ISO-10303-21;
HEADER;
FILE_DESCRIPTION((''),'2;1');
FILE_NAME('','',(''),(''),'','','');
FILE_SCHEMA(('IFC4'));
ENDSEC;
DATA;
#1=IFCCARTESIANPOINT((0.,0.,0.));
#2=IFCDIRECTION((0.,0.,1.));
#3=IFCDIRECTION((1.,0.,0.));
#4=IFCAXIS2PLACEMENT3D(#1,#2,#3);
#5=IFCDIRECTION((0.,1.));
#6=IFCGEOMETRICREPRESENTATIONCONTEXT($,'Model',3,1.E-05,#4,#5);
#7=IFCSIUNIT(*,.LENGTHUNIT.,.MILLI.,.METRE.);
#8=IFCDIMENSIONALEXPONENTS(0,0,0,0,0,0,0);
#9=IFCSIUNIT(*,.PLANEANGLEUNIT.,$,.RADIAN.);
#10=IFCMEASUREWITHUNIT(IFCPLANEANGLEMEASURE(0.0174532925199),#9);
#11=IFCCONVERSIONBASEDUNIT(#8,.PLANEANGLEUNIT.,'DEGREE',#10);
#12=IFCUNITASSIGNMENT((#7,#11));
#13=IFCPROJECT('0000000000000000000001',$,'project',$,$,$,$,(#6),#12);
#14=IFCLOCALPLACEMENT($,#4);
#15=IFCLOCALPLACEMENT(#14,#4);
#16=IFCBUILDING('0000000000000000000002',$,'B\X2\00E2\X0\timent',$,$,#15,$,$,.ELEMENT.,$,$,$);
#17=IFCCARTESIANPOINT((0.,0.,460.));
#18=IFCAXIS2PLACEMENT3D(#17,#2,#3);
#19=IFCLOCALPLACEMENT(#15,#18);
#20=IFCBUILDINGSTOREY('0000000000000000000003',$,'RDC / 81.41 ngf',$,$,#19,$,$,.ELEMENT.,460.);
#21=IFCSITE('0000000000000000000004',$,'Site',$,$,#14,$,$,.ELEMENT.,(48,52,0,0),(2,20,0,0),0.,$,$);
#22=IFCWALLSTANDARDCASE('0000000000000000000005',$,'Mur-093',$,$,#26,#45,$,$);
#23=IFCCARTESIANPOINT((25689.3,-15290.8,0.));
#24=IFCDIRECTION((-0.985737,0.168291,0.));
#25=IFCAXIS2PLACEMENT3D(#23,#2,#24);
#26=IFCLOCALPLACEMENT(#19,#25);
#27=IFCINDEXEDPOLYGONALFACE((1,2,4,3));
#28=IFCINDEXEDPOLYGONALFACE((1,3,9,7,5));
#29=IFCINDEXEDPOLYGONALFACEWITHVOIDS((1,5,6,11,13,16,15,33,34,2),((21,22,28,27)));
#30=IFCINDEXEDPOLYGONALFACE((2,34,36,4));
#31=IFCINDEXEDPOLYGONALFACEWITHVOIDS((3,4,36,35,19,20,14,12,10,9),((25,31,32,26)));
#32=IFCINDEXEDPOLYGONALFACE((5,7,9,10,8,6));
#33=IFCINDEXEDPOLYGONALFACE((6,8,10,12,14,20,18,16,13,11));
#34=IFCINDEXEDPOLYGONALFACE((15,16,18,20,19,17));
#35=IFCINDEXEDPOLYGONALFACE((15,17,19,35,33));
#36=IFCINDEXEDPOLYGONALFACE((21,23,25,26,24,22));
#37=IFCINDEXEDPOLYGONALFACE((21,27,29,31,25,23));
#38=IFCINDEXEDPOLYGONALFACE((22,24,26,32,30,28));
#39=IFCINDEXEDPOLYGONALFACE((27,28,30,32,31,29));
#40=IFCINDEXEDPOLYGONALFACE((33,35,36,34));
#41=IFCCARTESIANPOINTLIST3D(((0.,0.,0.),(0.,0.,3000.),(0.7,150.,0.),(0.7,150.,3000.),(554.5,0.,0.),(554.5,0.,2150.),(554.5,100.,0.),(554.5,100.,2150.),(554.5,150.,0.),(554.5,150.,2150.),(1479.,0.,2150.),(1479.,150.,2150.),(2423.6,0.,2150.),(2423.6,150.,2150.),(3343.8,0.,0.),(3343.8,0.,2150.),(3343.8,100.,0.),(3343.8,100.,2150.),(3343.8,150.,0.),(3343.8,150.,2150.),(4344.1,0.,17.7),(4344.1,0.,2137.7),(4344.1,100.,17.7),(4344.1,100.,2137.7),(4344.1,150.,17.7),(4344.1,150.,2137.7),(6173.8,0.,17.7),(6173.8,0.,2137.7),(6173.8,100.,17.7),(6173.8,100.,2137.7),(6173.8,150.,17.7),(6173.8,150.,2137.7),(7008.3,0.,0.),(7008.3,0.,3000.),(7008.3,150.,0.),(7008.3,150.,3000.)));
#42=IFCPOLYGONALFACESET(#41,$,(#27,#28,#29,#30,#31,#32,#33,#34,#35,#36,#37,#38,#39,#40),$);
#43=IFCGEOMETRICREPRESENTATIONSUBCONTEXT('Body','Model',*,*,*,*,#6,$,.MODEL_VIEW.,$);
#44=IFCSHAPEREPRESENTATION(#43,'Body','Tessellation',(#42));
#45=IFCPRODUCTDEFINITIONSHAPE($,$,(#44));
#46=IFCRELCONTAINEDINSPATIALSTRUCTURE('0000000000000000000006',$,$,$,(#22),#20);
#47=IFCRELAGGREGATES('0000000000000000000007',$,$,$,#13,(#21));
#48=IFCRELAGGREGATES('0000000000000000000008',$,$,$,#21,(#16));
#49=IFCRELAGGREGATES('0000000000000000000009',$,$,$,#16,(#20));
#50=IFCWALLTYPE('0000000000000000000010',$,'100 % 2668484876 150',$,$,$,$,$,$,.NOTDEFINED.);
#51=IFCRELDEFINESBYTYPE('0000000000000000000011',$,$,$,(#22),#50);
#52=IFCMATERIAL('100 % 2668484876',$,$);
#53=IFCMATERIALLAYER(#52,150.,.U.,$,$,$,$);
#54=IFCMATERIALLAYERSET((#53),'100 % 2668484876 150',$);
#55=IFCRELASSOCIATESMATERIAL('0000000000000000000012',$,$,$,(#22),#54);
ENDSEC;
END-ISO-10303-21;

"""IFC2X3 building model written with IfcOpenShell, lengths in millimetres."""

from ifc_helpers import new_model, entity, si_unit, converted_unit, direction, frame, origin_with_axes, origin_2d_with_axis, place, context, subcontext, project, spatial, polyline, rectangle, outline, extrude, material, layer, layer_set, layer_usage, type_object, element, save


model = new_model("IFC2X3")

# Units and contexts
model_context = context("Model", 3, precision=1e-05, world=origin_with_axes(), true_north=direction((0.0, 1.0)))
body_context = subcontext(model_context, "Body", "Model", "MODEL_VIEW")
ifc_project = project(units=[si_unit("LENGTHUNIT", "METRE", prefix="MILLI"), converted_unit("PLANEANGLEUNIT", "DEGREE", entity("IfcPlaneAngleMeasure", 0.0174532925199), si_unit("PLANEANGLEUNIT", "RADIAN"), dimensions=[0, 0, 0, 0, 0, 0, 0])], contexts=[model_context])

# Site, building, storey
site_placement = place(None, origin_with_axes())
site = spatial("IfcSite", under=ifc_project, at=site_placement, Name="Site", CompositionType="ELEMENT", RefLatitude=(48, 52, 0, 0), RefLongitude=(2, 20, 0, 0), RefElevation=0.0)
building_placement = place(site_placement, origin_with_axes())
building = spatial("IfcBuilding", under=site, at=building_placement, Name="Bâtiment", CompositionType="ELEMENT")
storey_placement = place(building_placement, frame((0.0, 0.0, 460.0), z_axis=(0.0, 0.0, 1.0), x_axis=(1.0, 0.0, 0.0)))
storey = spatial("IfcBuildingStorey", under=building, at=storey_placement, Name="RDC / 81.41 ngf", CompositionType="ELEMENT", Elevation=460.0)

# Shared definitions
ifc_material_1 = material(Name="100 % 2668484876")

# Wall, openings
ifc_layer_1 = layer(ifc_material_1, 150.0, ventilated="UNKNOWN")
ifc_layer_set_1 = layer_set([ifc_layer_1], Name="100 % 2668484876 150")
ifc_layer_usage_1 = layer_usage(ifc_layer_set_1, "AXIS2", "NEGATIVE", 150.0)
wall_type_1 = type_object("IfcWallType", Name="100 % 2668484876 150", PredefinedType="NOTDEFINED")
wall_1_placement = place(storey_placement, frame((25689.3, -15290.8, 0.0), z_axis=(0.0, 0.0, 1.0), x_axis=(-0.985737, 0.168291, 0.0)))
wall_1 = element("IfcWallStandardCase", 1, at=wall_1_placement, inside=storey, type_object=wall_type_1, material=ifc_layer_usage_1, Name="Mur-093", context=body_context, shape_type="SweptSolid", body=[
    extrude(outline(polyline([(0.0, 0.0), (7008.3, 0.0), (7008.3, 150.0), (0.7, 150.0), (0.0, 0.0)])), origin_with_axes(), (0.0, 0.0, 1.0), 3000.0),
])
opening_1_placement = place(wall_1_placement, frame((2883.7, 0.0, 0.0), z_axis=(0.0, 0.0, 1.0), x_axis=(1.0, 0.0, 0.0)))
element("IfcOpeningElement", 2, at=opening_1_placement, cuts=wall_1, context=body_context, shape_type="SweptSolid", body=[
    extrude(rectangle(XDim=920.2, YDim=2150.0, at=origin_2d_with_axis()), frame((0.0, -150.0, 1075.0), z_axis=(0.0, -1.0, 0.0), x_axis=(1.0, 0.0, 0.0)), (0.0, 0.0, -1.0), 250.0),
    extrude(rectangle(XDim=920.2, YDim=2150.0, at=origin_2d_with_axis()), frame((0.0, 300.0, 1075.0), z_axis=(0.0, 1.0, 0.0), x_axis=(1.0, 0.0, 0.0)), (0.0, 0.0, -1.0), 200.0),
])
opening_2_placement = place(wall_1_placement, frame((5258.9, 0.0, 17.7), z_axis=(0.0, 0.0, 1.0), x_axis=(1.0, 0.0, 0.0)))
element("IfcOpeningElement", 3, at=opening_2_placement, cuts=wall_1, context=body_context, shape_type="SweptSolid", body=[
    extrude(rectangle(XDim=1829.7, YDim=2120.0, at=origin_2d_with_axis()), frame((0.0, -150.0, 1060.0), z_axis=(0.0, 1.0, 0.0), x_axis=(1.0, 0.0, 0.0)), (0.0, 0.0, 1.0), 250.0),
    extrude(rectangle(XDim=1829.7, YDim=2120.0, at=origin_2d_with_axis()), frame((0.0, 300.0, 1060.0), z_axis=(0.0, -1.0, 0.0), x_axis=(1.0, 0.0, 0.0)), (0.0, 0.0, 1.0), 200.0),
])
opening_3_placement = place(wall_1_placement, frame((1951.3, 0.0, 0.0), z_axis=(0.0, 0.0, 1.0), x_axis=(1.0, 0.0, 0.0)))
element("IfcOpeningElement", 4, at=opening_3_placement, cuts=wall_1, context=body_context, shape_type="SweptSolid", body=[
    extrude(rectangle(XDim=944.6, YDim=2150.0, at=origin_2d_with_axis()), frame((0.0, -150.0, 1075.0), z_axis=(0.0, -1.0, 0.0), x_axis=(1.0, 0.0, 0.0)), (0.0, 0.0, -1.0), 250.0),
    extrude(rectangle(XDim=944.6, YDim=2150.0, at=origin_2d_with_axis()), frame((0.0, 300.0, 1075.0), z_axis=(0.0, 1.0, 0.0), x_axis=(1.0, 0.0, 0.0)), (0.0, 0.0, -1.0), 200.0),
])
opening_4_placement = place(wall_1_placement, frame((1016.7, 0.0, 0.0), z_axis=(0.0, 0.0, 1.0), x_axis=(1.0, 0.0, 0.0)))
element("IfcOpeningElement", 5, at=opening_4_placement, cuts=wall_1, context=body_context, shape_type="SweptSolid", body=[
    extrude(rectangle(XDim=924.5, YDim=2150.0, at=origin_2d_with_axis()), frame((0.0, -150.0, 1075.0), z_axis=(0.0, -1.0, 0.0), x_axis=(1.0, 0.0, 0.0)), (0.0, 0.0, -1.0), 250.0),
    extrude(rectangle(XDim=924.5, YDim=2150.0, at=origin_2d_with_axis()), frame((0.0, 300.0, 1075.0), z_axis=(0.0, 1.0, 0.0), x_axis=(1.0, 0.0, 0.0)), (0.0, 0.0, -1.0), 200.0),
])

save(model, "model.ifc")
